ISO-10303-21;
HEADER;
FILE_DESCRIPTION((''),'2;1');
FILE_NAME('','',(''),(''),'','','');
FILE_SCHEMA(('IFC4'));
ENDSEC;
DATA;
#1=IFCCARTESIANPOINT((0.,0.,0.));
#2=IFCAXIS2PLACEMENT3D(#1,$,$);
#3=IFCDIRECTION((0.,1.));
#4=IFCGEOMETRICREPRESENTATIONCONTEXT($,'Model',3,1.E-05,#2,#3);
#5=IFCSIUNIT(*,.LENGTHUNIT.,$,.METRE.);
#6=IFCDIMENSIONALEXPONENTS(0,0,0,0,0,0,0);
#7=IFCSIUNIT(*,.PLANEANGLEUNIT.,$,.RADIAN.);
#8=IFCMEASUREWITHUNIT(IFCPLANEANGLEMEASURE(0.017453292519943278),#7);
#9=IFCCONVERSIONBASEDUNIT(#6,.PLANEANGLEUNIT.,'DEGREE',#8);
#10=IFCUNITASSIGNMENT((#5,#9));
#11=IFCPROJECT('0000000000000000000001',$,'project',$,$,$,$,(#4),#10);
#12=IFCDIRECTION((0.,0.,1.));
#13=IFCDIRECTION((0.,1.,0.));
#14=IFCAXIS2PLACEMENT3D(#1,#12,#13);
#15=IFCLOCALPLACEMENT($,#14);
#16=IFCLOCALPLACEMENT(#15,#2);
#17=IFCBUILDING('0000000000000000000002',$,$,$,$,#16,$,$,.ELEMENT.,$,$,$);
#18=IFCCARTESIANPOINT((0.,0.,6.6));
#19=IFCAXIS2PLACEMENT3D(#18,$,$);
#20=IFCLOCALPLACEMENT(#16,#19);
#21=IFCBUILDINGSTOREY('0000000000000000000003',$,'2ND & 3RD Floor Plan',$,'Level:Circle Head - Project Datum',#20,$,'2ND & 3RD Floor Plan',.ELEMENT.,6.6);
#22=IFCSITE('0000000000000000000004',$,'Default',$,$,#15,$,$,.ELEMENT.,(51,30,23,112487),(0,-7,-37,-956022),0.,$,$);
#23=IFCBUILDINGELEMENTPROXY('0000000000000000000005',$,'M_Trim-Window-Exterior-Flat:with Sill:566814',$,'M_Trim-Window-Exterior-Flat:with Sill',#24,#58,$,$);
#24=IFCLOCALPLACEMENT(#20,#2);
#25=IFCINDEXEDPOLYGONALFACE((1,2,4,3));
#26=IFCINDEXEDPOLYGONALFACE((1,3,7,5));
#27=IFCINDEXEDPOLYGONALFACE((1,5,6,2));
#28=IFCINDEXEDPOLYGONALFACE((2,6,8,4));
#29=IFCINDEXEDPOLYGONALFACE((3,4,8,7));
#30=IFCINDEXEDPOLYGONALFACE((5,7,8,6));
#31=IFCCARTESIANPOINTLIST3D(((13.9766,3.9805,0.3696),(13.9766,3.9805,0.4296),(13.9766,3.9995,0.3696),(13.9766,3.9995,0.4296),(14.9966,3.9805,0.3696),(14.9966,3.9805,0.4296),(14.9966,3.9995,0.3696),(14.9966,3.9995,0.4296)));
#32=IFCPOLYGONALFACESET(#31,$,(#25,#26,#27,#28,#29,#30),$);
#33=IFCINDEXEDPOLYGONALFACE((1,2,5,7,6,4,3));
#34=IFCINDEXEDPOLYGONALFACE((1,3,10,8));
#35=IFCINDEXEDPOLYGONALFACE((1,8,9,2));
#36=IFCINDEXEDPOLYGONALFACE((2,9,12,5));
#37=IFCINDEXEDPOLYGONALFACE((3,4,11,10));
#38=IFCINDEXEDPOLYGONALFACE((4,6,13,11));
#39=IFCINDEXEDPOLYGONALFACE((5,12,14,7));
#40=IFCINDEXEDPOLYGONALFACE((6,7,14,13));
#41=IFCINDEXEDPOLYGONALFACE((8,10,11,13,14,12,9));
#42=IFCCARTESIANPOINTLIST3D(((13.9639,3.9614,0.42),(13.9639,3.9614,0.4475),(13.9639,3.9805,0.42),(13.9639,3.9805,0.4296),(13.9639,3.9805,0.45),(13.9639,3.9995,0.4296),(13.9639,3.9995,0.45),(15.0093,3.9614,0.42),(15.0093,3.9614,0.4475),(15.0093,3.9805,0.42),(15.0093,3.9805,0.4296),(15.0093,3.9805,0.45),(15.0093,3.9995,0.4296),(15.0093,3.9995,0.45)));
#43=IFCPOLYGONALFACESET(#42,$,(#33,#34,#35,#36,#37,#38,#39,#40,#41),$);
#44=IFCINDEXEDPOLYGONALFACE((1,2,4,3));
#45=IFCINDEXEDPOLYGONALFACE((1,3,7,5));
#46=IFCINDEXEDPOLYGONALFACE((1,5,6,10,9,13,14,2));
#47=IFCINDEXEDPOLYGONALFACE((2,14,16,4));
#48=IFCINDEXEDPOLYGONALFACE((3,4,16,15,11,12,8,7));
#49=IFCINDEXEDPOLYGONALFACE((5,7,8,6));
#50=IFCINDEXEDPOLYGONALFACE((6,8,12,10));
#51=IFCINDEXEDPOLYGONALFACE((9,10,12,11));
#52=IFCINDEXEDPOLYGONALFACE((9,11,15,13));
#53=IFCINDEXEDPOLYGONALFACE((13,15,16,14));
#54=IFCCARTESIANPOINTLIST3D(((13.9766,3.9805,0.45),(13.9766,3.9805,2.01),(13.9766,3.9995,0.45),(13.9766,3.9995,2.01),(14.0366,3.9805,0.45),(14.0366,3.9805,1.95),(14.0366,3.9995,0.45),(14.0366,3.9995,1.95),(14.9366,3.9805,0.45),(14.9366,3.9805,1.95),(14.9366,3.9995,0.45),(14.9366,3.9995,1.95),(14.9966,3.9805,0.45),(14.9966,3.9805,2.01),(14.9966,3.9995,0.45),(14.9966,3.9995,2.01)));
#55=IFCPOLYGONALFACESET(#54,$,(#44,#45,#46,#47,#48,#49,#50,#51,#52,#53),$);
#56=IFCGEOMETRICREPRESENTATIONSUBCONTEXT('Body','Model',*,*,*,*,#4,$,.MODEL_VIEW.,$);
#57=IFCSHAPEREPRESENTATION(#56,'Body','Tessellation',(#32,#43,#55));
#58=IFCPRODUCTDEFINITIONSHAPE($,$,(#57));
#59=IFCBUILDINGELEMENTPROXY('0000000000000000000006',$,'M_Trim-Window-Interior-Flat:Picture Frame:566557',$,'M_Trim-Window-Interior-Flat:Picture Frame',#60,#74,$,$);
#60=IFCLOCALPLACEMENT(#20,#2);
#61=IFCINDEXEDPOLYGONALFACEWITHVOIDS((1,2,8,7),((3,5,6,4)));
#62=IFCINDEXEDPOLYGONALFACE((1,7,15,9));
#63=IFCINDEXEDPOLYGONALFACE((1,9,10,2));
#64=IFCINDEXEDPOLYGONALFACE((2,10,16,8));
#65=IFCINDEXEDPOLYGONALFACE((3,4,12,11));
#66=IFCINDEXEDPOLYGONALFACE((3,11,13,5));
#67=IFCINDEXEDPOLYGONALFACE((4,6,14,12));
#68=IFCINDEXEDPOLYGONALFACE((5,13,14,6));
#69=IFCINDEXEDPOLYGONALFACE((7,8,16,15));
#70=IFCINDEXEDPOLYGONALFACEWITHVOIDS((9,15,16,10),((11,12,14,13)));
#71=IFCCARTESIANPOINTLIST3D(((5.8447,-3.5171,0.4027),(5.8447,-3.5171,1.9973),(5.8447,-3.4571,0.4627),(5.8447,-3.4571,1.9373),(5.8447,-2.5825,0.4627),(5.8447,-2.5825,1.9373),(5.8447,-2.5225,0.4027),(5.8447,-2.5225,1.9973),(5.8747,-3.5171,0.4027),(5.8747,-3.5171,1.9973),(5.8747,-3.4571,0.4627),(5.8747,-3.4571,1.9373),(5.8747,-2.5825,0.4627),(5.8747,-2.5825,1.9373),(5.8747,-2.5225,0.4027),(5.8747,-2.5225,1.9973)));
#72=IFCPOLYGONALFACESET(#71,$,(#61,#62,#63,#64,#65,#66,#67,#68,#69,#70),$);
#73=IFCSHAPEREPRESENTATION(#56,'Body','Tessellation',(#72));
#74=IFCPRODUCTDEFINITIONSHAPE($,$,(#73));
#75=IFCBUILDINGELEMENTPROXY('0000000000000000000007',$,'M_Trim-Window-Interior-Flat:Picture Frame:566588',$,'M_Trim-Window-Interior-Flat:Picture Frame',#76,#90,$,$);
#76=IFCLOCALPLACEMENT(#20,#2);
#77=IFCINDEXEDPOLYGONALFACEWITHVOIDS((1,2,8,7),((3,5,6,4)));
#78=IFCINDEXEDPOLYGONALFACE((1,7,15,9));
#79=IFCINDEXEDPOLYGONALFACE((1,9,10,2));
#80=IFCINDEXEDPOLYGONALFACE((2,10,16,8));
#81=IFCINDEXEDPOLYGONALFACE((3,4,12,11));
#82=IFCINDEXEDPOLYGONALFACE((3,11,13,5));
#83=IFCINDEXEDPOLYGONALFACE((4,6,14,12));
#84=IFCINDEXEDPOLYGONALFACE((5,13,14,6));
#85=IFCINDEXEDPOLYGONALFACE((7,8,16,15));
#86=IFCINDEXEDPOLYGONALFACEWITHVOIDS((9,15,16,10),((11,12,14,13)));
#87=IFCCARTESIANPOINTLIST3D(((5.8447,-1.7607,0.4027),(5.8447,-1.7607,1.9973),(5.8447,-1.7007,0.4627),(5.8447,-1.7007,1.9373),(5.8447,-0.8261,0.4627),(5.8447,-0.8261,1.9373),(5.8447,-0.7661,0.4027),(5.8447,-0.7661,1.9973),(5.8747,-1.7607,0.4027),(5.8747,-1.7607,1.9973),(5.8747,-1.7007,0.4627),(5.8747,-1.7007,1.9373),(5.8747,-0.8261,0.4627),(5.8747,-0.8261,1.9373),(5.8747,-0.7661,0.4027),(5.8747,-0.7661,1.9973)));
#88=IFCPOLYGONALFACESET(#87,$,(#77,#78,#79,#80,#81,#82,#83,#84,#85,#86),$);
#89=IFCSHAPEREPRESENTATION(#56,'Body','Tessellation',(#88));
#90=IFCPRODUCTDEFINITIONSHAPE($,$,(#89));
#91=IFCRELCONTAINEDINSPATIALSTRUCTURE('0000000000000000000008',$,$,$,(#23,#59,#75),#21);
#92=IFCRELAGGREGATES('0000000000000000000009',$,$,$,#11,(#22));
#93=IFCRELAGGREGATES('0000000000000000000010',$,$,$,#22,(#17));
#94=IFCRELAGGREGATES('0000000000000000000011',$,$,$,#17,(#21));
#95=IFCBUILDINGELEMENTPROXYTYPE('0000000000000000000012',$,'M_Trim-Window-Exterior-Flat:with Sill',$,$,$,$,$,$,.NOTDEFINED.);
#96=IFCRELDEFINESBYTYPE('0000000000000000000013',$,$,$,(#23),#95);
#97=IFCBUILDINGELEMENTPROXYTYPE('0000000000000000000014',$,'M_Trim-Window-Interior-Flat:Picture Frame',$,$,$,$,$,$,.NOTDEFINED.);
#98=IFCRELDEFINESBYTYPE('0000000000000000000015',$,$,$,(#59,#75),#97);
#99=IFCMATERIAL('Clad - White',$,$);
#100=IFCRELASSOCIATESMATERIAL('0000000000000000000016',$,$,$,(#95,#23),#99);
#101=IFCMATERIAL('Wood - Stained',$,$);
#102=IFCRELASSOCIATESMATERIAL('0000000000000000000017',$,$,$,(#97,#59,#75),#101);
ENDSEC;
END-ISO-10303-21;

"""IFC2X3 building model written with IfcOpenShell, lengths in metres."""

from ifc_helpers import new_model, entity, si_unit, converted_unit, direction, frame, frame_2d, origin, place, context, subcontext, project, spatial, polyline, rectangle, outline, extrude, source, transform, mapped, material, type_object, type_shapes, element, save


model = new_model("IFC2X3")

# Units and contexts
model_context = context("Model", 3, precision=1e-05, world=origin(), true_north=direction((0.0, 1.0)))
body_context = subcontext(model_context, "Body", "Model", "MODEL_VIEW")
ifc_project = project(units=[si_unit("LENGTHUNIT", "METRE"), converted_unit("PLANEANGLEUNIT", "DEGREE", entity("IfcPlaneAngleMeasure", 0.017453292519943278), si_unit("PLANEANGLEUNIT", "RADIAN"), dimensions=[0, 0, 0, 0, 0, 0, 0])], contexts=[model_context])

# Site, building, storey
site_placement = place(None, frame((0.0, 0.0, 0.0), z_axis=(0.0, 0.0, 1.0), x_axis=(0.0, 1.0, 0.0)))
site = spatial("IfcSite", under=ifc_project, at=site_placement, Name="Default", CompositionType="ELEMENT", RefLatitude=(51, 30, 23, 112487), RefLongitude=(0, -7, -37, -956022), RefElevation=0.0)
building_placement = place(site_placement, origin())
building = spatial("IfcBuilding", under=site, at=building_placement, CompositionType="ELEMENT")
storey_placement = place(building_placement, frame((0.0, 0.0, 6.6)))
storey = spatial("IfcBuildingStorey", under=building, at=storey_placement, Name="2ND & 3RD Floor Plan", ObjectType="Level:Circle Head - Project Datum", LongName="2ND & 3RD Floor Plan", CompositionType="ELEMENT", Elevation=6.6)

# Building element proxies
ifc_material_1 = material(Name="Clad - White")
ifc_material_2 = material(Name="Wood - Stained")
building_element_proxy_type_1 = type_object("IfcBuildingElementProxyType", Name="M_Trim-Window-Exterior-Flat:with Sill", PredefinedType="NOTDEFINED", material=ifc_material_1)
shared_shape_1 = source(origin(), body_context, "Body", "SweptSolid", [
    extrude(rectangle(XDim=1.02, YDim=0.06, at=frame_2d((0.0, 0.0), x_axis=(1.0, 0.0))), frame((0.0, -1.5504, 0.0), z_axis=(0.0, 0.0, 1.0), x_axis=(-1.0, 0.0, 0.0)), (0.0, 0.0, 1.0), 0.019),
    extrude(outline(polyline([(-0.019, -0.0152), (0.0, -0.0152), (0.0, -0.0057), (0.019, -0.0057), (0.019, 0.0148), (0.0, 0.0148), (-0.019, 0.0123), (-0.019, -0.0152)])), frame((-0.5227, -1.5148, 0.019), z_axis=(1.0, 0.0, 0.0), x_axis=(0.0, 0.0, -1.0)), (0.0, 0.0, 1.0), 1.0454),
    extrude(outline(polyline([(-0.795, -0.51), (0.765, -0.51), (0.765, -0.45), (-0.735, -0.45), (-0.735, 0.45), (0.765, 0.45), (0.765, 0.51), (-0.795, 0.51), (-0.795, -0.51)])), frame((0.0, -0.735, 0.0), z_axis=(0.0, 0.0, 1.0), x_axis=(0.0, -1.0, 0.0)), (0.0, 0.0, 1.0), 0.019),
])
type_shapes(building_element_proxy_type_1, [shared_shape_1])
proxy_1_placement = place(storey_placement, frame((14.4866, 3.9995, 1.95), z_axis=(0.0, -1.0, 0.0), x_axis=(1.0, 0.0, 0.0)))
element("IfcBuildingElementProxy", 1, at=proxy_1_placement, inside=storey, type_object=building_element_proxy_type_1, material=ifc_material_1, Name="M_Trim-Window-Exterior-Flat:with Sill:566814", ObjectType="M_Trim-Window-Exterior-Flat:with Sill", context=body_context, shape_type="MappedRepresentation", body=[
    mapped(shared_shape_1, transform((0.0, 0.0, 0.0), scale=1.0)),
])
building_element_proxy_type_2 = type_object("IfcBuildingElementProxyType", Name="M_Trim-Window-Interior-Flat:Picture Frame", PredefinedType="NOTDEFINED", material=ifc_material_2)
shared_shape_2 = source(origin(), body_context, "Body", "SweptSolid", [
    extrude(outline(polyline([(-0.4973, -0.7973), (0.4973, -0.7973), (0.4973, 0.7973), (-0.4973, 0.7973), (-0.4973, -0.7973)]), holes=[polyline([(-0.4373, -0.7373), (-0.4373, 0.7373), (0.4373, 0.7373), (0.4373, -0.7373), (-0.4373, -0.7373)])]), frame((0.0, -0.75, 0.0), z_axis=(0.0, 0.0, 1.0), x_axis=(-1.0, 0.0, 0.0)), (0.0, 0.0, 1.0), 0.03),
])
type_shapes(building_element_proxy_type_2, [shared_shape_2])
for number, where, z_axis, x_axis, name in (
    (2, (5.8447, -3.0198, 1.95), (1.0, 0.0, 0.0), (0.0, 1.0, 0.0), "M_Trim-Window-Interior-Flat:Picture Frame:566557"),
    (3, (5.8447, -1.2634, 1.95), (1.0, 0.0, 0.0), (0.0, 1.0, 0.0), "M_Trim-Window-Interior-Flat:Picture Frame:566588"),
):
    element("IfcBuildingElementProxy", number, at=place(storey_placement, frame(where, z_axis=z_axis, x_axis=x_axis)), inside=storey, type_object=building_element_proxy_type_2, material=ifc_material_2, Name=name, ObjectType="M_Trim-Window-Interior-Flat:Picture Frame", context=body_context, shape_type="MappedRepresentation", body=[
        mapped(shared_shape_2, transform((0.0, 0.0, 0.0), scale=1.0)),
    ])

save(model, "model.ifc")
